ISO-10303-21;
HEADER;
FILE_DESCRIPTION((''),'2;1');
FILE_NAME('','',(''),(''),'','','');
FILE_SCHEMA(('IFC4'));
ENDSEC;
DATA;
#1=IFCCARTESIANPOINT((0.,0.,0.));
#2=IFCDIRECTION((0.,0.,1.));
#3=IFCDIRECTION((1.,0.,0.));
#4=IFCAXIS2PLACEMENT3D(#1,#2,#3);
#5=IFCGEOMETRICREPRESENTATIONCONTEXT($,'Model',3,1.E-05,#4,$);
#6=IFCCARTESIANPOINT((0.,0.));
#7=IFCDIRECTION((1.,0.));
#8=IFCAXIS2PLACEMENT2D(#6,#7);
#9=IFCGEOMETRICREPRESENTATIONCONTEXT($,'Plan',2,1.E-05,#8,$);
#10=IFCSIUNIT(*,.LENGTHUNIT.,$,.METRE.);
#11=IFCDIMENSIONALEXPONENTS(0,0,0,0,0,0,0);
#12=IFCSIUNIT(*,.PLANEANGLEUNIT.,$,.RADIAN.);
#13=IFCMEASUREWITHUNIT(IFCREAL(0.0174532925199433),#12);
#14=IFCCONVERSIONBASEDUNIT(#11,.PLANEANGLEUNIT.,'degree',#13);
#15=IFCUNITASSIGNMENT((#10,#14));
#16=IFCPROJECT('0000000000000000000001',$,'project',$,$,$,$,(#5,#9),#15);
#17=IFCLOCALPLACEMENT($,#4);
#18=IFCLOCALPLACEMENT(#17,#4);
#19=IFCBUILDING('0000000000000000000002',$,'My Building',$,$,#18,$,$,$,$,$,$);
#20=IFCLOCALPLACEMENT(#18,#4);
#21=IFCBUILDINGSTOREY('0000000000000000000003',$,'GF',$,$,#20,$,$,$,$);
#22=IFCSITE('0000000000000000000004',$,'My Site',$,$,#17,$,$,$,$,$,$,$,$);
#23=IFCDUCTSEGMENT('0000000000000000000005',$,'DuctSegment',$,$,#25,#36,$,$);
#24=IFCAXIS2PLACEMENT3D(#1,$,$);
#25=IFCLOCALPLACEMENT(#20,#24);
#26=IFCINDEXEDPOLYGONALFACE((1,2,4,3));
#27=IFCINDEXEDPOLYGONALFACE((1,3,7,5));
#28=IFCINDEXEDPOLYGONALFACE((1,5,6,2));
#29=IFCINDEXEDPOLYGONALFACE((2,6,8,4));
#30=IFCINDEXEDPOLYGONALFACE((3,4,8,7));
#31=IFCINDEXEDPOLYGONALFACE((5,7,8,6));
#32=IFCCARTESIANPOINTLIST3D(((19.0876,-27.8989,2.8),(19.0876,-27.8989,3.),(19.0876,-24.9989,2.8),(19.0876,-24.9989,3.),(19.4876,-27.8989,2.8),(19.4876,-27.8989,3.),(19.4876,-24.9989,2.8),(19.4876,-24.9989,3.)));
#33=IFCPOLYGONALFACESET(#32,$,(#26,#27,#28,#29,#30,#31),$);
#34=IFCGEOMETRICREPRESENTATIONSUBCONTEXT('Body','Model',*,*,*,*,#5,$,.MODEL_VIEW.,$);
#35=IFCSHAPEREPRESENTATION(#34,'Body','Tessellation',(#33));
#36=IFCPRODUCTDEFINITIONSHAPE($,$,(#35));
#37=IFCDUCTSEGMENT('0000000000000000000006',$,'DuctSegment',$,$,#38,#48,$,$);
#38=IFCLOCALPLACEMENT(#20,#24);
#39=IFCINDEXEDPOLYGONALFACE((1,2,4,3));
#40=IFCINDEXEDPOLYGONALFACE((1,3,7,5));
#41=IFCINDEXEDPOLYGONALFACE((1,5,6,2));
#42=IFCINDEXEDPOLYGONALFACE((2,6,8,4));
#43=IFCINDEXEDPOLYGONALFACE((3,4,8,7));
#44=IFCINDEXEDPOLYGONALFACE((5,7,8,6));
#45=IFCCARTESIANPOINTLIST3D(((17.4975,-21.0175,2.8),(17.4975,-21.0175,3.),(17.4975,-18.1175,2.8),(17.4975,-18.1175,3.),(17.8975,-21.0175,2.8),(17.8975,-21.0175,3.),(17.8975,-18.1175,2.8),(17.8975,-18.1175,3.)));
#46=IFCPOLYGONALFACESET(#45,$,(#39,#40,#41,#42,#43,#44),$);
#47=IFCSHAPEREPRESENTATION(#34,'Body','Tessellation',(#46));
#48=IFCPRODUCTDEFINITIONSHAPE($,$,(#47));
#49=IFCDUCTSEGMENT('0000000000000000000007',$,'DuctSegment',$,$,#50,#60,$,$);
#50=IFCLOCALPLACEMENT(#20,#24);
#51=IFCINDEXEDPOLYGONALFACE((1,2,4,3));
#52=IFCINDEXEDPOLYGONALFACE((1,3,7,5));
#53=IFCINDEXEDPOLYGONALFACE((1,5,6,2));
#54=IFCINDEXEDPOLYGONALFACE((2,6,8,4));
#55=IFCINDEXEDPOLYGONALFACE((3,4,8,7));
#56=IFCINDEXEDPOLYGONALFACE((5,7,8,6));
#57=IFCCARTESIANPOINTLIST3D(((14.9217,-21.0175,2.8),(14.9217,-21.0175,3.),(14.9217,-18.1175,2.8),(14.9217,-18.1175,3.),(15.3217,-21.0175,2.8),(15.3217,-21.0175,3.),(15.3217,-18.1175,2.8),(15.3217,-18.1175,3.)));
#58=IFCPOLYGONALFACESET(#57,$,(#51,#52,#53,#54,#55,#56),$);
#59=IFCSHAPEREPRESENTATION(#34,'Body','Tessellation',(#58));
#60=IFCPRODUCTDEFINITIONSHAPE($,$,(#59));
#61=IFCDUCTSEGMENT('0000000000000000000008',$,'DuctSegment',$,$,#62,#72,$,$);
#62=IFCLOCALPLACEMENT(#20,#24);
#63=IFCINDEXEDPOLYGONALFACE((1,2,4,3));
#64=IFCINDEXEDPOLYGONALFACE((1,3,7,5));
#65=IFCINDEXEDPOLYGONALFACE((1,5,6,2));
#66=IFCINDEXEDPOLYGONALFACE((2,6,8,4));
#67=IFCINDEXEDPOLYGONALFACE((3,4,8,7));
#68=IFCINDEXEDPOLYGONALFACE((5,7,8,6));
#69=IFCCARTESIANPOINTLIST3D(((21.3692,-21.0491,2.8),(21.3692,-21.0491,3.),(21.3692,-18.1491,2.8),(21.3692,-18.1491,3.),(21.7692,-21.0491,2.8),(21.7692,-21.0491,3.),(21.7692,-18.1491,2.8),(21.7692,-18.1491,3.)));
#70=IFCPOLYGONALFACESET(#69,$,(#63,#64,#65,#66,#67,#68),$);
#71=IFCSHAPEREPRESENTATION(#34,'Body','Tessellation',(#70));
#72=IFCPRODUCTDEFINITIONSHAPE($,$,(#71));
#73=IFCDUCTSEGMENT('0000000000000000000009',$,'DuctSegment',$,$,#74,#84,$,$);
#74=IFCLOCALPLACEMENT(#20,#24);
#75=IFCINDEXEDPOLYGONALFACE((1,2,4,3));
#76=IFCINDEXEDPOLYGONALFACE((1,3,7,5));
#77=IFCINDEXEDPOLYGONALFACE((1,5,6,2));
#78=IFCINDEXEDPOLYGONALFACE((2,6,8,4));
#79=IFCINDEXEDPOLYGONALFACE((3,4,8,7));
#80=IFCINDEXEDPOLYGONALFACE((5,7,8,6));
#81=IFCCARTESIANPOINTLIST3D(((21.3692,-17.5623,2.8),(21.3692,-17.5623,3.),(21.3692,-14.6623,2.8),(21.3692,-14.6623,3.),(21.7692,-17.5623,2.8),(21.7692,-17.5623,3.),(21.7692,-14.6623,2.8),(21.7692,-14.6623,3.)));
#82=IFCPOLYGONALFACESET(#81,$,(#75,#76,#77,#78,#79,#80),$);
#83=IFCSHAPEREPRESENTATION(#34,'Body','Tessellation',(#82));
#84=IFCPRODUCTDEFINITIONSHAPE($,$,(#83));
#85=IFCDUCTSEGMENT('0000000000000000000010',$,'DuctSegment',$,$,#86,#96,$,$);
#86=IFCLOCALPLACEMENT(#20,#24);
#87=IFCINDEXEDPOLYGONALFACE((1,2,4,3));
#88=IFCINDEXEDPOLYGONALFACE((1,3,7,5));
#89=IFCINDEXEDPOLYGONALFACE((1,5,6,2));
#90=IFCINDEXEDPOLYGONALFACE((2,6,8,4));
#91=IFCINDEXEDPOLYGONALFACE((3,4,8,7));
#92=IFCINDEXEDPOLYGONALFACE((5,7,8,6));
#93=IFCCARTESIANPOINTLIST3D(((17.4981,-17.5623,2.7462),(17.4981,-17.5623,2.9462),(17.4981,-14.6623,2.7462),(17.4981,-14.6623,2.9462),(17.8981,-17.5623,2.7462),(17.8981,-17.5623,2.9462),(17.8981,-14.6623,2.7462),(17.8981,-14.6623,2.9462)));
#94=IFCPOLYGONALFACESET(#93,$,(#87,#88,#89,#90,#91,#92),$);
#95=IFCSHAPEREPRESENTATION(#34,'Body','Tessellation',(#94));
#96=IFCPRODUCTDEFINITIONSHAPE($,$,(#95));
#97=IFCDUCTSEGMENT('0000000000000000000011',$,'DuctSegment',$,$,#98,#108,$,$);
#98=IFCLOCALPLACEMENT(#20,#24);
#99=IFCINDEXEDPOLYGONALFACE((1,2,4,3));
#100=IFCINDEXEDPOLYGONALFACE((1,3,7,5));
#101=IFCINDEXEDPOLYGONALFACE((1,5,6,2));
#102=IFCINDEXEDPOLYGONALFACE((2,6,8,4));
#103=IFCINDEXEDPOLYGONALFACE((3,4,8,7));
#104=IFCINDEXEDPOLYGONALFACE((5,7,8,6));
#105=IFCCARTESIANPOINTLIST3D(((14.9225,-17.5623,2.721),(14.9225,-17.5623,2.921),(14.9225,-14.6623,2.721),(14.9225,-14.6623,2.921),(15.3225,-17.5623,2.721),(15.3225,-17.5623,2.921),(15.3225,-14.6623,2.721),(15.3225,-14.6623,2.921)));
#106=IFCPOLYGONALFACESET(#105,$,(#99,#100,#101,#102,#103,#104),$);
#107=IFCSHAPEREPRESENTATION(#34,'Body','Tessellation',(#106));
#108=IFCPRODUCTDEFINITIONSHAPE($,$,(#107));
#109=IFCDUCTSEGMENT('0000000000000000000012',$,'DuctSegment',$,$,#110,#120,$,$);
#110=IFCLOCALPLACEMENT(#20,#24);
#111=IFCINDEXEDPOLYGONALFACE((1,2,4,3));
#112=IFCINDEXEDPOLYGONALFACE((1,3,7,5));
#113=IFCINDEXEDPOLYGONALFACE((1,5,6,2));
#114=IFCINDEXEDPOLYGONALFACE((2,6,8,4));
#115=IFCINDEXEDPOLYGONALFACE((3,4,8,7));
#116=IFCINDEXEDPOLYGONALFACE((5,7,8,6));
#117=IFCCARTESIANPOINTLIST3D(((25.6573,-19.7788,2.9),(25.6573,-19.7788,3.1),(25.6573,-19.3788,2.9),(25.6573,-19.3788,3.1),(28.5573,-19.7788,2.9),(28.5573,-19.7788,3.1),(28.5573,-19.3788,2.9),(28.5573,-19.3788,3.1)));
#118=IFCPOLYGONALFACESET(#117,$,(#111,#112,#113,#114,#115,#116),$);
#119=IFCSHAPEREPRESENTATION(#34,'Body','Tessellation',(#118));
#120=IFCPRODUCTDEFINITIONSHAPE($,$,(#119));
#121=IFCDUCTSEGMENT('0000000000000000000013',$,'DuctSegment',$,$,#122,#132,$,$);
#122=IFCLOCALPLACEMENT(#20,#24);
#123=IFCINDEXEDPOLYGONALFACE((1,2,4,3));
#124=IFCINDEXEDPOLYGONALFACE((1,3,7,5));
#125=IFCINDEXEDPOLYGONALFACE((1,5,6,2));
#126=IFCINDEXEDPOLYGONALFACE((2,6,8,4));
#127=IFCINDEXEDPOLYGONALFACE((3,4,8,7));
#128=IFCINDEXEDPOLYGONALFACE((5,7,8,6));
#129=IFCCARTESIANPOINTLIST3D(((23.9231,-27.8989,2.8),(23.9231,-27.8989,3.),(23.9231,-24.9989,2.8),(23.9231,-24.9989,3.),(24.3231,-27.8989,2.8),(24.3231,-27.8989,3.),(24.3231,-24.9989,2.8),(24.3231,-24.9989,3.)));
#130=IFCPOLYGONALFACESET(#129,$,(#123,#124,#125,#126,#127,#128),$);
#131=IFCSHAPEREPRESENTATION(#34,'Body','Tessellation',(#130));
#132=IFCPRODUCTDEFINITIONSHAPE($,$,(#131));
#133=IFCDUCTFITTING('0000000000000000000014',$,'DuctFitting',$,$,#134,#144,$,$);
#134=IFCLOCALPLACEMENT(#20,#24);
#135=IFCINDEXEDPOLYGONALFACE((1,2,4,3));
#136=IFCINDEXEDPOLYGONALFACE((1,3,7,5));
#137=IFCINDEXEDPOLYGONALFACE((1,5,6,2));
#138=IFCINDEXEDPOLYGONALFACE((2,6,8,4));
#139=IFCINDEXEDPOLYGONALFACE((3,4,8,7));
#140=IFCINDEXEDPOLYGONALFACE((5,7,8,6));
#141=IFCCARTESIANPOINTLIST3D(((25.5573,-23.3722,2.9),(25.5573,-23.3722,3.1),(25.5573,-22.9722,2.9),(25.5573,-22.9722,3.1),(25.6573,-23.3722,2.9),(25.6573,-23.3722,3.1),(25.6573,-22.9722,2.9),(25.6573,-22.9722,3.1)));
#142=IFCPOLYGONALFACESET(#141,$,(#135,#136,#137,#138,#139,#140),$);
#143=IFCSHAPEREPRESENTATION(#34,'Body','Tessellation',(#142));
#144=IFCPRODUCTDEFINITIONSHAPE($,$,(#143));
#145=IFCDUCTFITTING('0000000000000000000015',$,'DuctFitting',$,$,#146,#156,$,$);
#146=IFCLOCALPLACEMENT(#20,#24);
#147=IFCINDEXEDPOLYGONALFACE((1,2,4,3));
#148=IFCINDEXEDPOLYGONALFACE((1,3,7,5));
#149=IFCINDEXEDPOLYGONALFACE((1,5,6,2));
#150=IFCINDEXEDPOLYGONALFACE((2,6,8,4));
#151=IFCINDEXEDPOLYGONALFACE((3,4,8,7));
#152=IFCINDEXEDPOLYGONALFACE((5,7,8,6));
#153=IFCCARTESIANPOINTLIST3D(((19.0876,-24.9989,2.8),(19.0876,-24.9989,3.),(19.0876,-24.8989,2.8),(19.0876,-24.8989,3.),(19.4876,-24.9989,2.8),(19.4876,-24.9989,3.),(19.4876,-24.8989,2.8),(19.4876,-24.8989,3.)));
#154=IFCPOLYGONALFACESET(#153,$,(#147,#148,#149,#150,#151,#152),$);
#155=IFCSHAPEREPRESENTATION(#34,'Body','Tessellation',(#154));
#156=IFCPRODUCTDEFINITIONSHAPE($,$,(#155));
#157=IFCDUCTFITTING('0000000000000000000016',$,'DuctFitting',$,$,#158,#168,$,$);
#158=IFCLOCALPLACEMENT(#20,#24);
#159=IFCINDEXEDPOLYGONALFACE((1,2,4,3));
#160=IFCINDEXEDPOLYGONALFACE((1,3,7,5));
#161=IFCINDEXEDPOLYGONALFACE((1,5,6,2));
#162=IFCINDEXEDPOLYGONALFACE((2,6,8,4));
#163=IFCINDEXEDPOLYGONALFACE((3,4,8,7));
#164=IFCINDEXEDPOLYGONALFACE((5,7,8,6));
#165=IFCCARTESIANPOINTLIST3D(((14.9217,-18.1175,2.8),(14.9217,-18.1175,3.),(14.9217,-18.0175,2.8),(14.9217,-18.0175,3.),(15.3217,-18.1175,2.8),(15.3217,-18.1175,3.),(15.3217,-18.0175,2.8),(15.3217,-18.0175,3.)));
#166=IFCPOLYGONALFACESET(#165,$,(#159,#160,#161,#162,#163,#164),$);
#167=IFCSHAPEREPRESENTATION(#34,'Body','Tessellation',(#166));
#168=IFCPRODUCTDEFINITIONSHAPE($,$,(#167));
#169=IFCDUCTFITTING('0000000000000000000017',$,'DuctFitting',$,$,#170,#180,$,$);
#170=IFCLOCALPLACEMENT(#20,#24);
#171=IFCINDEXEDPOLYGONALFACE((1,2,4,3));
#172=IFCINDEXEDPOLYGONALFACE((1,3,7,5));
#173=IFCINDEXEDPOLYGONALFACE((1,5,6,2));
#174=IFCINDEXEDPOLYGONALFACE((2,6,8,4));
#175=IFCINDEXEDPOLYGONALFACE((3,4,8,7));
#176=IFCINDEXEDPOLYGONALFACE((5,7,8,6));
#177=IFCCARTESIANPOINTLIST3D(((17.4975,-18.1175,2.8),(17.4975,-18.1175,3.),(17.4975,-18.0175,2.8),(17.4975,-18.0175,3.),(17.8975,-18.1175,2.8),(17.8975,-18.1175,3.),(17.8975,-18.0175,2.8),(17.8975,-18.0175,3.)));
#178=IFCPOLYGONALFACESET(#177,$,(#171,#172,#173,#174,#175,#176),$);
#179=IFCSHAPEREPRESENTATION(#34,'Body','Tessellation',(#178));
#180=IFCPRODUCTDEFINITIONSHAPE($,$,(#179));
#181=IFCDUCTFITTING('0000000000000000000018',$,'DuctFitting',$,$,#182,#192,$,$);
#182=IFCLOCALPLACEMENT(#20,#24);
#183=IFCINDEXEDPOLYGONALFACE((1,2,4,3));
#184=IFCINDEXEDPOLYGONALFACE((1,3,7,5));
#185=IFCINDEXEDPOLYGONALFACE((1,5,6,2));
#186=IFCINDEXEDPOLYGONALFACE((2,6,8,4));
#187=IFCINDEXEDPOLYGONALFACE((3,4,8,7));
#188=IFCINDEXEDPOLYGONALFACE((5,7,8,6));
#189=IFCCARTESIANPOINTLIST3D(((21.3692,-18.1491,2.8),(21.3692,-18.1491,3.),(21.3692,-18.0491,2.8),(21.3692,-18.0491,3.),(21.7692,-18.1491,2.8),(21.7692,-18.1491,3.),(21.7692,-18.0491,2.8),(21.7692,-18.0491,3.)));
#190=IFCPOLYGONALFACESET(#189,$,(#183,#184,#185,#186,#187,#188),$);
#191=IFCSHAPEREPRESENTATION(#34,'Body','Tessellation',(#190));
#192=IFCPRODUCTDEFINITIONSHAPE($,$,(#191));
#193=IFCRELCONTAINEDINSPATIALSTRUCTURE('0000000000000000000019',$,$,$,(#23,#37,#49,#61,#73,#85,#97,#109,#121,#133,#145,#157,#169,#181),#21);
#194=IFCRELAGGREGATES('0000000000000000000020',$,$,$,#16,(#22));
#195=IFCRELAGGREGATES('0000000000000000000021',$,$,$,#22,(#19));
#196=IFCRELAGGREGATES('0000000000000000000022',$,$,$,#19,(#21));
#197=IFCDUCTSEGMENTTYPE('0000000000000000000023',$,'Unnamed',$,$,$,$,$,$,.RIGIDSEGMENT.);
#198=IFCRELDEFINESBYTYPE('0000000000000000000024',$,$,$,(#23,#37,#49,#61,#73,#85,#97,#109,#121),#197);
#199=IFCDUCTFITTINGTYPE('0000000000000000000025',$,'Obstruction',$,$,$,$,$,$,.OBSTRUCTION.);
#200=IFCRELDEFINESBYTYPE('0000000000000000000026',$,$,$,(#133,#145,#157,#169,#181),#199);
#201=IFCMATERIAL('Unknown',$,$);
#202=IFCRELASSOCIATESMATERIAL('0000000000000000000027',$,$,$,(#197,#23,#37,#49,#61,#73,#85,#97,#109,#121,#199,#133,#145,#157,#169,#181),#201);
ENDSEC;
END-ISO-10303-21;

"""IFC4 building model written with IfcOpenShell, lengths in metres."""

from ifc_helpers import new_model, entity, si_unit, converted_unit, frame, origin_with_axes, origin_2d_with_axis, place, context, subcontext, project, spatial, rectangle, extrude, material, material_profile, profile_set, profile_usage, type_object, element, save


model = new_model("IFC4")

# Units and contexts
model_context = context("Model", 3, precision=1e-05, world=origin_with_axes())
plan_context = context("Plan", 2, precision=1e-05, world=origin_2d_with_axis())
body_context_1 = subcontext(model_context, "Body", "Model", "MODEL_VIEW")
ifc_project = project(units=[si_unit("LENGTHUNIT", "METRE"), converted_unit("PLANEANGLEUNIT", "degree", entity("IfcReal", 0.0174532925199433), si_unit("PLANEANGLEUNIT", "RADIAN"), dimensions=[0, 0, 0, 0, 0, 0, 0])], contexts=[model_context, plan_context])

# Site, building, storey
site_placement = place(None, origin_with_axes())
site = spatial("IfcSite", under=ifc_project, at=site_placement, Name="My Site")
building_placement = place(site_placement, origin_with_axes())
building = spatial("IfcBuilding", under=site, at=building_placement, Name="My Building")
storey_placement = place(building_placement, origin_with_axes())
storey = spatial("IfcBuildingStorey", under=building, at=storey_placement, Name="GF")

# Shared definitions
ifc_material = material(Name="Unknown")

# Duct segments
ifc_material_profile_1 = material_profile(ifc_material, rectangle(XDim=0.4, YDim=0.2))
ifc_profile_set_1 = profile_set([ifc_material_profile_1])
duct_segment_type = type_object("IfcDuctSegmentType", Name="Unnamed", PredefinedType="RIGIDSEGMENT", material=ifc_profile_set_1)
ifc_profile_usage_1 = profile_usage(ifc_profile_set_1, cardinal=5)
duct_segment_1_placement = place(storey_placement, frame((19.2876, -24.9989, 2.9), z_axis=(0.0, -1.0, 0.0), x_axis=(1.0, 0.0, 0.0)))
element("IfcDuctSegment", 1, at=duct_segment_1_placement, inside=storey, type_object=duct_segment_type, material=ifc_profile_usage_1, Name="DuctSegment", context=body_context_1, shape_type="SweptSolid", body=[
    extrude(rectangle(XDim=0.4, YDim=0.2), origin_with_axes(), (0.0, 0.0, 1.0), 2.9),
])
ifc_profile_usage_2 = profile_usage(ifc_profile_set_1, cardinal=5)
duct_segment_2_placement = place(storey_placement, frame((17.6975, -18.1175, 2.9), z_axis=(0.0, -1.0, 0.0), x_axis=(1.0, 0.0, 0.0)))
element("IfcDuctSegment", 2, at=duct_segment_2_placement, inside=storey, type_object=duct_segment_type, material=ifc_profile_usage_2, Name="DuctSegment", context=body_context_1, shape_type="SweptSolid", body=[
    extrude(rectangle(XDim=0.4, YDim=0.2), origin_with_axes(), (0.0, 0.0, 1.0), 2.9),
])
ifc_profile_usage_3 = profile_usage(ifc_profile_set_1, cardinal=5)
duct_segment_3_placement = place(storey_placement, frame((15.1217, -18.1175, 2.9), z_axis=(0.0, -1.0, 0.0), x_axis=(1.0, 0.0, 0.0)))
element("IfcDuctSegment", 3, at=duct_segment_3_placement, inside=storey, type_object=duct_segment_type, material=ifc_profile_usage_3, Name="DuctSegment", context=body_context_1, shape_type="SweptSolid", body=[
    extrude(rectangle(XDim=0.4, YDim=0.2), origin_with_axes(), (0.0, 0.0, 1.0), 2.9),
])
ifc_profile_usage_4 = profile_usage(ifc_profile_set_1, cardinal=5)
duct_segment_4_placement = place(storey_placement, frame((21.5692, -18.1491, 2.9), z_axis=(0.0, -1.0, 0.0), x_axis=(1.0, 0.0, 0.0)))
element("IfcDuctSegment", 4, at=duct_segment_4_placement, inside=storey, type_object=duct_segment_type, material=ifc_profile_usage_4, Name="DuctSegment", context=body_context_1, shape_type="SweptSolid", body=[
    extrude(rectangle(XDim=0.4, YDim=0.2), origin_with_axes(), (0.0, 0.0, 1.0), 2.9),
])
ifc_profile_usage_5 = profile_usage(ifc_profile_set_1, cardinal=5)
duct_segment_5_placement = place(storey_placement, frame((21.5692, -14.6623, 2.9), z_axis=(0.0, -1.0, 0.0), x_axis=(1.0, 0.0, 0.0)))
element("IfcDuctSegment", 5, at=duct_segment_5_placement, inside=storey, type_object=duct_segment_type, material=ifc_profile_usage_5, Name="DuctSegment", context=body_context_1, shape_type="SweptSolid", body=[
    extrude(rectangle(XDim=0.4, YDim=0.2), origin_with_axes(), (0.0, 0.0, 1.0), 2.9),
])
ifc_profile_usage_6 = profile_usage(ifc_profile_set_1, cardinal=5)
duct_segment_6_placement = place(storey_placement, frame((17.6981, -14.6623, 2.8462), z_axis=(0.0, -1.0, 0.0), x_axis=(1.0, 0.0, 0.0)))
element("IfcDuctSegment", 6, at=duct_segment_6_placement, inside=storey, type_object=duct_segment_type, material=ifc_profile_usage_6, Name="DuctSegment", context=body_context_1, shape_type="SweptSolid", body=[
    extrude(rectangle(XDim=0.4, YDim=0.2), origin_with_axes(), (0.0, 0.0, 1.0), 2.9),
])
ifc_profile_usage_7 = profile_usage(ifc_profile_set_1, cardinal=5)
duct_segment_7_placement = place(storey_placement, frame((15.1225, -14.6623, 2.821), z_axis=(0.0, -1.0, 0.0), x_axis=(1.0, 0.0, 0.0)))
element("IfcDuctSegment", 7, at=duct_segment_7_placement, inside=storey, type_object=duct_segment_type, material=ifc_profile_usage_7, Name="DuctSegment", context=body_context_1, shape_type="SweptSolid", body=[
    extrude(rectangle(XDim=0.4, YDim=0.2), origin_with_axes(), (0.0, 0.0, 1.0), 2.9),
])
ifc_profile_usage_8 = profile_usage(ifc_profile_set_1, cardinal=5)
duct_segment_8_placement = place(storey_placement, frame((25.6573, -19.5788, 3.0), z_axis=(1.0, 0.0, 0.0), x_axis=(0.0, 1.0, 0.0)))
element("IfcDuctSegment", 8, at=duct_segment_8_placement, inside=storey, type_object=duct_segment_type, material=ifc_profile_usage_8, Name="DuctSegment", context=body_context_1, shape_type="SweptSolid", body=[
    extrude(rectangle(XDim=0.4, YDim=0.2), origin_with_axes(), (0.0, 0.0, 1.0), 2.9),
])
ifc_profile_usage_9 = profile_usage(ifc_profile_set_1, cardinal=5)
duct_segment_9_placement = place(storey_placement, frame((24.1231, -24.9989, 2.9), z_axis=(0.0, -1.0, 0.0), x_axis=(1.0, 0.0, 0.0)))
element("IfcDuctSegment", 9, at=duct_segment_9_placement, inside=storey, type_object=duct_segment_type, material=ifc_profile_usage_9, Name="DuctSegment", context=body_context_1, shape_type="SweptSolid", body=[
    extrude(rectangle(XDim=0.4, YDim=0.2), origin_with_axes(), (0.0, 0.0, 1.0), 2.9),
])

# Duct fittings
ifc_material_profile_2 = material_profile(ifc_material, rectangle(XDim=0.4, YDim=0.2))
ifc_profile_set_2 = profile_set([ifc_material_profile_2])
ifc_profile_usage_10 = profile_usage(ifc_profile_set_2, cardinal=5)
duct_fitting_type = type_object("IfcDuctFittingType", Name="Obstruction", PredefinedType="OBSTRUCTION", material=ifc_profile_set_2)
duct_fitting_1_placement = place(storey_placement, frame((25.5573, -23.1722, 3.0), z_axis=(1.0, 0.0, 0.0), x_axis=(0.0, 1.0, 0.0)))
element("IfcDuctFitting", 10, at=duct_fitting_1_placement, inside=storey, type_object=duct_fitting_type, material=ifc_profile_usage_10, Name="DuctFitting", context=body_context_1, shape_type="SweptSolid", body=[
    extrude(rectangle(XDim=0.4, YDim=0.2), origin_with_axes(), (0.0, 0.0, 1.0), 0.1),
])
ifc_profile_usage_11 = profile_usage(ifc_profile_set_2, cardinal=5)
duct_fitting_2_placement = place(storey_placement, frame((19.2876, -24.8989, 2.9), z_axis=(0.0, -1.0, 0.0), x_axis=(1.0, 0.0, 0.0)))
element("IfcDuctFitting", 11, at=duct_fitting_2_placement, inside=storey, type_object=duct_fitting_type, material=ifc_profile_usage_11, Name="DuctFitting", context=body_context_1, shape_type="SweptSolid", body=[
    extrude(rectangle(XDim=0.4, YDim=0.2), origin_with_axes(), (0.0, 0.0, 1.0), 0.1),
])
ifc_profile_usage_12 = profile_usage(ifc_profile_set_2, cardinal=5)
duct_fitting_3_placement = place(storey_placement, frame((15.1217, -18.0175, 2.9), z_axis=(0.0, -1.0, 0.0), x_axis=(1.0, 0.0, 0.0)))
element("IfcDuctFitting", 12, at=duct_fitting_3_placement, inside=storey, type_object=duct_fitting_type, material=ifc_profile_usage_12, Name="DuctFitting", context=body_context_1, shape_type="SweptSolid", body=[
    extrude(rectangle(XDim=0.4, YDim=0.2), origin_with_axes(), (0.0, 0.0, 1.0), 0.1),
])
ifc_profile_usage_13 = profile_usage(ifc_profile_set_2, cardinal=5)
duct_fitting_4_placement = place(storey_placement, frame((17.6975, -18.0175, 2.9), z_axis=(0.0, -1.0, 0.0), x_axis=(1.0, 0.0, 0.0)))
element("IfcDuctFitting", 13, at=duct_fitting_4_placement, inside=storey, type_object=duct_fitting_type, material=ifc_profile_usage_13, Name="DuctFitting", context=body_context_1, shape_type="SweptSolid", body=[
    extrude(rectangle(XDim=0.4, YDim=0.2), origin_with_axes(), (0.0, 0.0, 1.0), 0.1),
])
ifc_profile_usage_14 = profile_usage(ifc_profile_set_2, cardinal=5)
duct_fitting_5_placement = place(storey_placement, frame((21.5692, -18.0491, 2.9), z_axis=(0.0, -1.0, 0.0), x_axis=(1.0, 0.0, 0.0)))
element("IfcDuctFitting", 14, at=duct_fitting_5_placement, inside=storey, type_object=duct_fitting_type, material=ifc_profile_usage_14, Name="DuctFitting", context=body_context_1, shape_type="SweptSolid", body=[
    extrude(rectangle(XDim=0.4, YDim=0.2), origin_with_axes(), (0.0, 0.0, 1.0), 0.1),
])

save(model, "model.ifc")
